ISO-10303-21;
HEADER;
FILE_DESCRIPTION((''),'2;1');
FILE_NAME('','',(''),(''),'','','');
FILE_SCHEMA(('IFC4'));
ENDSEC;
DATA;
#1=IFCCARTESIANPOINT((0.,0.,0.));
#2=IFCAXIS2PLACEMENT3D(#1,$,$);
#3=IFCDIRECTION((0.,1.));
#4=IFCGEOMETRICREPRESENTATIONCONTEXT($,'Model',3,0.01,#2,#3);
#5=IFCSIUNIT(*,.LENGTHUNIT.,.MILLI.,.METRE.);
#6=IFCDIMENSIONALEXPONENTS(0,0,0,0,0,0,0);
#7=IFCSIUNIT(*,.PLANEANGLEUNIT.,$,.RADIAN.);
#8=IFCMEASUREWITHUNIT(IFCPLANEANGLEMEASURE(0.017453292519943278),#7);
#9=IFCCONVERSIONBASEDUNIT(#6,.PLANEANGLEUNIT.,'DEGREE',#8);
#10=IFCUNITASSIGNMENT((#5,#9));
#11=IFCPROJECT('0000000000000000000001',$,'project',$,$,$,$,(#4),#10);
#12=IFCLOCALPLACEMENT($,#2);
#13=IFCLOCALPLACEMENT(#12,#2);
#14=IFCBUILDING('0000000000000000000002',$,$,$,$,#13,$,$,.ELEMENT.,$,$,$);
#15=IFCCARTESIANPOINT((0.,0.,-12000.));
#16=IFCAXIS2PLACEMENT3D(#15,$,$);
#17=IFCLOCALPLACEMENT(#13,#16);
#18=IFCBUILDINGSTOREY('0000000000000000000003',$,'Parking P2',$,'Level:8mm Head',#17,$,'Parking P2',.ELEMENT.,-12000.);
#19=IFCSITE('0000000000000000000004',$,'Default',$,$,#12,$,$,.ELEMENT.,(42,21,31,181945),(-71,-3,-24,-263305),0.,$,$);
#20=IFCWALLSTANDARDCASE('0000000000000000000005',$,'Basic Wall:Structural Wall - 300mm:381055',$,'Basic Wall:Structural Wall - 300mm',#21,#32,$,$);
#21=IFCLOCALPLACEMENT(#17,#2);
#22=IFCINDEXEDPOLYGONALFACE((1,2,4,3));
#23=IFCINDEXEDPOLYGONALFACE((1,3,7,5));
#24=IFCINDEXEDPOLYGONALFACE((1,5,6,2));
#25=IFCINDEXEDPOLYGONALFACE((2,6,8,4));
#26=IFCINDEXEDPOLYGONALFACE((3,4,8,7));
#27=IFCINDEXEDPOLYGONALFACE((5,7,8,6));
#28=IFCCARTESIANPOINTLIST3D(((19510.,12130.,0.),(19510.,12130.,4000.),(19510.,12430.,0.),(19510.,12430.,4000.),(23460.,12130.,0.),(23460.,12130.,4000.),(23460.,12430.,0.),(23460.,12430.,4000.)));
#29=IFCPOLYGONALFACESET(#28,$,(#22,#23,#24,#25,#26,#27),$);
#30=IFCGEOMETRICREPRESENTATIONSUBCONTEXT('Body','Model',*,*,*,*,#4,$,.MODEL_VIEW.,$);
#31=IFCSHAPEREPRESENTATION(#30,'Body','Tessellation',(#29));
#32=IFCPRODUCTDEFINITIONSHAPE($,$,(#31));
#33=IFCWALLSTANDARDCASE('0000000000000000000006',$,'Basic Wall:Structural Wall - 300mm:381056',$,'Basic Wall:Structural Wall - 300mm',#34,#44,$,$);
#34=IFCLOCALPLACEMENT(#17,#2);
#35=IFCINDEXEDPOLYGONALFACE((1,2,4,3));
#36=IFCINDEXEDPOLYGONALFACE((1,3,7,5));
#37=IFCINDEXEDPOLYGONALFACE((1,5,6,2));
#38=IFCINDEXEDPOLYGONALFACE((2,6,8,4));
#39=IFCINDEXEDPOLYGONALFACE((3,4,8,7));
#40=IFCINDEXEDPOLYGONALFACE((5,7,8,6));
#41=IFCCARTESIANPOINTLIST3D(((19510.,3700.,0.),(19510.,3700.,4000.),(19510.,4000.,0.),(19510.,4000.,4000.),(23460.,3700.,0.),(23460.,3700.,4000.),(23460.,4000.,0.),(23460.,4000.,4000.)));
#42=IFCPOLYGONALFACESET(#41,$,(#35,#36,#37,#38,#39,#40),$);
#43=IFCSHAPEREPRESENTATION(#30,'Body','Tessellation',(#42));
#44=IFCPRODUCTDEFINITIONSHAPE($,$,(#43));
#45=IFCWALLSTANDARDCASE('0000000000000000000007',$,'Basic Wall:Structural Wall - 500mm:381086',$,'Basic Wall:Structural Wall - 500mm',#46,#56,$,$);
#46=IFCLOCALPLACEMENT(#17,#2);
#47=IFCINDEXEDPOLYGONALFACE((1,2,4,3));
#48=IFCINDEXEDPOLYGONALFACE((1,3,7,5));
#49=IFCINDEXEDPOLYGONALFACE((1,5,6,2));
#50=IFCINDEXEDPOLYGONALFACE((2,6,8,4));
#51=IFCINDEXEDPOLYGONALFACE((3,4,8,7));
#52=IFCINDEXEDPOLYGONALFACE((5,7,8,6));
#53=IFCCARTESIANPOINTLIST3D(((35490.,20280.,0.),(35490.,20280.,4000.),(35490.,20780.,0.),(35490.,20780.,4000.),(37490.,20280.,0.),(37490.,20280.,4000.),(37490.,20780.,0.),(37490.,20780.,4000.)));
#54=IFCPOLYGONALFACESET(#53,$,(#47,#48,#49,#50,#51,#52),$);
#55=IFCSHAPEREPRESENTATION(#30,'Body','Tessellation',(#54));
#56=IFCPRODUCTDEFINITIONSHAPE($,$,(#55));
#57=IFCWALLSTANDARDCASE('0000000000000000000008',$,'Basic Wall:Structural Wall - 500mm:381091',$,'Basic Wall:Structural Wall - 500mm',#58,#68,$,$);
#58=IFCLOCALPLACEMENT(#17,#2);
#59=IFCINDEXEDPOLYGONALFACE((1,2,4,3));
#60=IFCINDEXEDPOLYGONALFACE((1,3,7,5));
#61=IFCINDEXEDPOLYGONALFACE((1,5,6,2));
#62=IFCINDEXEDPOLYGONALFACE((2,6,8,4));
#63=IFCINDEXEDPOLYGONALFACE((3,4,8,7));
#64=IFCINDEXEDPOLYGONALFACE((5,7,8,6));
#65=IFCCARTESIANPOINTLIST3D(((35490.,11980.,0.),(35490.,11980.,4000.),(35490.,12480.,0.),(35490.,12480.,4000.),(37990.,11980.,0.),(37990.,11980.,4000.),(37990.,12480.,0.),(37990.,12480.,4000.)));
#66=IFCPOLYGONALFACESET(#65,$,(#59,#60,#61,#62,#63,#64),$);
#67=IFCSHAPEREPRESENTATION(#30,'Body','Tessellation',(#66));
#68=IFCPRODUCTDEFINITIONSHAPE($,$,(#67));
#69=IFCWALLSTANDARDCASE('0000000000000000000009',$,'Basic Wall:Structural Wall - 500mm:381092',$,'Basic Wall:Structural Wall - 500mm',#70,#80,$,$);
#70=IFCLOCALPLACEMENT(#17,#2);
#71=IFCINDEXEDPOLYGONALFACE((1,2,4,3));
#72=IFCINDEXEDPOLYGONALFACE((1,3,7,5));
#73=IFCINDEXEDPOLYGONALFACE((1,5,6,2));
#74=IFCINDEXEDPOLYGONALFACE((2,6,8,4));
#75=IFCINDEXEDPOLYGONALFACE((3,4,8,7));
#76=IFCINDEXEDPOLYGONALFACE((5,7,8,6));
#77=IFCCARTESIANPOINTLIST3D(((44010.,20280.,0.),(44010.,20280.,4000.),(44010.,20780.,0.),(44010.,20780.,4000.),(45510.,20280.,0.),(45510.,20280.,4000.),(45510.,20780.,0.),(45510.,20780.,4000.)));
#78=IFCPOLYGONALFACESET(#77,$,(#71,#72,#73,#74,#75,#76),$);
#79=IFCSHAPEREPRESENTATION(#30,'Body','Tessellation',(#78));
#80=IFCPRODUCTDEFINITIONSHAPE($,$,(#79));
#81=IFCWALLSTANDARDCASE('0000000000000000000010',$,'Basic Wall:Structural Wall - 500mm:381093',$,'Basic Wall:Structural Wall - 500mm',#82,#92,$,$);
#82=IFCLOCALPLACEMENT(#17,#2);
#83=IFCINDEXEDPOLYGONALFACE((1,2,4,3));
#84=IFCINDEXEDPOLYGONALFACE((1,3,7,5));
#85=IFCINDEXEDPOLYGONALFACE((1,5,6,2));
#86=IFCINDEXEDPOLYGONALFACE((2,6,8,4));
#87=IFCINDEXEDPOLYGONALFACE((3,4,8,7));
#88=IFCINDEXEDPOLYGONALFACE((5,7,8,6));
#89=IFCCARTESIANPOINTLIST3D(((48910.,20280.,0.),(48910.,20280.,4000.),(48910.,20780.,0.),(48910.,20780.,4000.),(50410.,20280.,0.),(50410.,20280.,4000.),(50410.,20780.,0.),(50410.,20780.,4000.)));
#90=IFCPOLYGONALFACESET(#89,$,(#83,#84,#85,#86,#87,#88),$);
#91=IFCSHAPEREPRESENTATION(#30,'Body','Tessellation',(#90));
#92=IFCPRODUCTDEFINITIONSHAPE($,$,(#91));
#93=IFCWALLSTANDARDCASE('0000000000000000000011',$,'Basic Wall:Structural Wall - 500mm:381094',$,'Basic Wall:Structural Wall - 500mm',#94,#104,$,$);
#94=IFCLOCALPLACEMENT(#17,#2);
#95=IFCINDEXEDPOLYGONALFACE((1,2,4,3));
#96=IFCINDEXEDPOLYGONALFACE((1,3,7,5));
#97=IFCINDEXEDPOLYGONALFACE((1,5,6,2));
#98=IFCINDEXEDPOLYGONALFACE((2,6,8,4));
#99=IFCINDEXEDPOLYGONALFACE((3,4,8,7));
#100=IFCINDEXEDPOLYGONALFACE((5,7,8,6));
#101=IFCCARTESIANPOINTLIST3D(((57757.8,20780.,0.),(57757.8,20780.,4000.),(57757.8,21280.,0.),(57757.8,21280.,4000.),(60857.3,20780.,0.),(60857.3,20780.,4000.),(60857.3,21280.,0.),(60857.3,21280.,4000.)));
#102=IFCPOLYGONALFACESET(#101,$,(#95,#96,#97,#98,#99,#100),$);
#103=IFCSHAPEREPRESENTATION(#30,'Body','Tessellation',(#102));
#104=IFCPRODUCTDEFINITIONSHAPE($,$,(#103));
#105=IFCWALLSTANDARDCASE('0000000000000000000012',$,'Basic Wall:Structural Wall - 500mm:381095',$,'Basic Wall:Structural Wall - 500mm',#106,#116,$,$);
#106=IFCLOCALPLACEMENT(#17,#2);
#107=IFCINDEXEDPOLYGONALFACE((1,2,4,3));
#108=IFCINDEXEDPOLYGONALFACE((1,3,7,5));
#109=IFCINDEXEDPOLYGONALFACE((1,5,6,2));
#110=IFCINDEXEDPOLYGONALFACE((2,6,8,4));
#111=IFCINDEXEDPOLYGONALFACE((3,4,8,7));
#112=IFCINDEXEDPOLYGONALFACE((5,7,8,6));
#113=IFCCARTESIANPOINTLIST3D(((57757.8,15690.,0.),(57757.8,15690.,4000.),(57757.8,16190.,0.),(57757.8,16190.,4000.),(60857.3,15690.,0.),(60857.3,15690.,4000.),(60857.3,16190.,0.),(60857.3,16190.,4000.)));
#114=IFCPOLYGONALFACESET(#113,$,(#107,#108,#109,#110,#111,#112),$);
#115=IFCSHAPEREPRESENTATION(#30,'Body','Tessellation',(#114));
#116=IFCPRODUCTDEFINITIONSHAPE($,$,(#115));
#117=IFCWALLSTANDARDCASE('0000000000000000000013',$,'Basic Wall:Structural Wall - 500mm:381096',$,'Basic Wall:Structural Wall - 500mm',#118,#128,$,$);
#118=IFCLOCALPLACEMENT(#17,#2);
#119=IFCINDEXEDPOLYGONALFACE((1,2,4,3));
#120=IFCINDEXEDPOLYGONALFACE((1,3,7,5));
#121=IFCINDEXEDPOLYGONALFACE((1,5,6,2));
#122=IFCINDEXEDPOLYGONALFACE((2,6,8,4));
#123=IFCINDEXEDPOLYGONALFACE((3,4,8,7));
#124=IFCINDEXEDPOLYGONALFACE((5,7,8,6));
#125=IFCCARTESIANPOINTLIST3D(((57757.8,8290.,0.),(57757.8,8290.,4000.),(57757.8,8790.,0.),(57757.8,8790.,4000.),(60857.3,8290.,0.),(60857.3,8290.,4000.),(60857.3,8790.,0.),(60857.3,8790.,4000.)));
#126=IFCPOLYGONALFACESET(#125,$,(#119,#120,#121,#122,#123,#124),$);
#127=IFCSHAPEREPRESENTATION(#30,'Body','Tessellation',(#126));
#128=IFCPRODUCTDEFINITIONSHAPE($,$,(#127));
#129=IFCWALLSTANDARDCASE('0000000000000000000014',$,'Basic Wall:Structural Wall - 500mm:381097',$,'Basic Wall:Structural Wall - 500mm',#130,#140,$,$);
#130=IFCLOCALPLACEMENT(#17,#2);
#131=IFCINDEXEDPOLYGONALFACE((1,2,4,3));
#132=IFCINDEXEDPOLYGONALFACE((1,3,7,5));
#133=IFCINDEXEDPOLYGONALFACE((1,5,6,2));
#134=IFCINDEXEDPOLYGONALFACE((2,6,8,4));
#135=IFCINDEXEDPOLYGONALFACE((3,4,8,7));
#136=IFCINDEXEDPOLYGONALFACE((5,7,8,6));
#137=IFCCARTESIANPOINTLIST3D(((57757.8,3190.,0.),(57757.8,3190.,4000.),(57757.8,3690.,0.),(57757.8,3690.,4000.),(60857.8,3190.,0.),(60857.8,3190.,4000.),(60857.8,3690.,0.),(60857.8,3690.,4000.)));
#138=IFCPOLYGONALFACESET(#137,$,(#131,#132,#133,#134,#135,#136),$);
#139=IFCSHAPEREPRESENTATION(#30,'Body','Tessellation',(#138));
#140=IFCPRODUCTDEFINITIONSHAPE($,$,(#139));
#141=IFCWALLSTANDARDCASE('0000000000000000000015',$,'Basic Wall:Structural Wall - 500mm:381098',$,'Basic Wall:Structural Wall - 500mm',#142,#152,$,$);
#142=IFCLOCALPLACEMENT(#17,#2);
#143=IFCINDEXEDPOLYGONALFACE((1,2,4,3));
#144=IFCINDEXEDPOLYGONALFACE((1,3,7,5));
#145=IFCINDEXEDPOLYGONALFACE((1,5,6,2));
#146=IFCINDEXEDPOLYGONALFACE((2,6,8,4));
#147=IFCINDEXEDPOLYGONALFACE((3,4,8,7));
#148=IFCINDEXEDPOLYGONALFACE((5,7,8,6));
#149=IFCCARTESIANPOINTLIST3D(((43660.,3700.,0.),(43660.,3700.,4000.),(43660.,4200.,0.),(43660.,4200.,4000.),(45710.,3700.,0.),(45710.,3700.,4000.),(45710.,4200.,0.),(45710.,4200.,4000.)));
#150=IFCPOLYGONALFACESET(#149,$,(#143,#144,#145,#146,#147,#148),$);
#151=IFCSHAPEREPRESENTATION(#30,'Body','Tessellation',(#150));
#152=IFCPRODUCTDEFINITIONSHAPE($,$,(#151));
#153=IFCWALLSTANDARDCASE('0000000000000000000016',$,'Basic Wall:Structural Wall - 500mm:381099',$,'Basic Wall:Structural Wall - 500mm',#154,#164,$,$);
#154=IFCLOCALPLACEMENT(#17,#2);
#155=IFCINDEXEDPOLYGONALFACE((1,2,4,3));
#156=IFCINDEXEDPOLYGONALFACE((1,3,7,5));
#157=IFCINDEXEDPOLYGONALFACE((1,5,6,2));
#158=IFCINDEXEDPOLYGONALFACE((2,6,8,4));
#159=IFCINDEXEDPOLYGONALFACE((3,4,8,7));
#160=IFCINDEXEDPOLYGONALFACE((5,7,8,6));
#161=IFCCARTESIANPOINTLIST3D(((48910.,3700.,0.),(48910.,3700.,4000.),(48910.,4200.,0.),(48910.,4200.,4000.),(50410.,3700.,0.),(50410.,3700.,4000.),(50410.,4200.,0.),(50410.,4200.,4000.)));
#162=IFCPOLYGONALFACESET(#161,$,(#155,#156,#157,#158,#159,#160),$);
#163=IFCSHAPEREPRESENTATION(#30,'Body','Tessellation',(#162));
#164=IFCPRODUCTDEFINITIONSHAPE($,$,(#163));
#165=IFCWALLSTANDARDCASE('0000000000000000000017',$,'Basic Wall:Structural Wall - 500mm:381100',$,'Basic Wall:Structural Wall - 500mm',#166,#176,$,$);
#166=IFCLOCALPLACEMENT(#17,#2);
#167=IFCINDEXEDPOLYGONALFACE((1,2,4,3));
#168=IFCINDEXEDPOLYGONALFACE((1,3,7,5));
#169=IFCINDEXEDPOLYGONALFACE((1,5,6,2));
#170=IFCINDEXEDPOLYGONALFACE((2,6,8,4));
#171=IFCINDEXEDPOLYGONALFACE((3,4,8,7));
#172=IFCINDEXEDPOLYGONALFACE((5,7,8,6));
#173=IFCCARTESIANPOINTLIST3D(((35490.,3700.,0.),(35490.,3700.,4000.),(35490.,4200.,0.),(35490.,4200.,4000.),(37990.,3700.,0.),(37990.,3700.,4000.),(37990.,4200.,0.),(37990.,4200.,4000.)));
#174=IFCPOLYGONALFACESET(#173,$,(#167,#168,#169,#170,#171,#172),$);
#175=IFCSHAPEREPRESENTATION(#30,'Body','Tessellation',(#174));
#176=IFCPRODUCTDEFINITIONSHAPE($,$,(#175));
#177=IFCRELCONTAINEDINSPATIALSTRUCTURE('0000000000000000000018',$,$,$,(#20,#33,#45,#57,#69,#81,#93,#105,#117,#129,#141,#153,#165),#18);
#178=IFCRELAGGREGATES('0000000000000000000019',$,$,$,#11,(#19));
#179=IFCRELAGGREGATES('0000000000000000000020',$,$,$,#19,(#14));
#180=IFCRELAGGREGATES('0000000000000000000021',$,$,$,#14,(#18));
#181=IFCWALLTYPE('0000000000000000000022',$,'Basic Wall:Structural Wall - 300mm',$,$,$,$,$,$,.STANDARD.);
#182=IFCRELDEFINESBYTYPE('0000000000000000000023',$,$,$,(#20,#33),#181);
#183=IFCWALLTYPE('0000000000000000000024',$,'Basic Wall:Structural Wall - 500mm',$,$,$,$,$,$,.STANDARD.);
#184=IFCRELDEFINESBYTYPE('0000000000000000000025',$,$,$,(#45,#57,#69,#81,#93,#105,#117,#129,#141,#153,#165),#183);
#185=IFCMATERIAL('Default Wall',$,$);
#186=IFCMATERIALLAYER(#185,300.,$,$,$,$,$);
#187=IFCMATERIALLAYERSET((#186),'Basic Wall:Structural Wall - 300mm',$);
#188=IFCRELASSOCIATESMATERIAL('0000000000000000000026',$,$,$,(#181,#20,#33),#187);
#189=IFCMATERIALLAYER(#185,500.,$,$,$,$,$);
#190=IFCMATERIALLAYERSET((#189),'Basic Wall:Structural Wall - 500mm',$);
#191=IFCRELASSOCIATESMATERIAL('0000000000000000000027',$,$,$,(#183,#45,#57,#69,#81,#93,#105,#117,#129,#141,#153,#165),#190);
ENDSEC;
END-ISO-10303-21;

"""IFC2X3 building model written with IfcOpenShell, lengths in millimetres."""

from ifc_helpers import new_model, entity, si_unit, converted_unit, direction, frame, frame_2d, origin, place, context, subcontext, project, spatial, rectangle, extrude, material, layer, layer_set, layer_usage, type_object, element, save


model = new_model("IFC2X3")

# Units and contexts
model_context = context("Model", 3, precision=0.01, world=origin(), true_north=direction((0.0, 1.0)))
body_context = subcontext(model_context, "Body", "Model", "MODEL_VIEW")
ifc_project = project(units=[si_unit("LENGTHUNIT", "METRE", prefix="MILLI"), converted_unit("PLANEANGLEUNIT", "DEGREE", entity("IfcPlaneAngleMeasure", 0.017453292519943278), si_unit("PLANEANGLEUNIT", "RADIAN"), dimensions=[0, 0, 0, 0, 0, 0, 0])], contexts=[model_context])

# Site, building, storey
site_placement = place(None, origin())
site = spatial("IfcSite", under=ifc_project, at=site_placement, Name="Default", CompositionType="ELEMENT", RefLatitude=(42, 21, 31, 181945), RefLongitude=(-71, -3, -24, -263305), RefElevation=0.0)
building_placement = place(site_placement, origin())
building = spatial("IfcBuilding", under=site, at=building_placement, CompositionType="ELEMENT")
storey_placement = place(building_placement, frame((0.0, 0.0, -12000.0)))
storey = spatial("IfcBuildingStorey", under=building, at=storey_placement, Name="Parking P2", ObjectType="Level:8mm Head", LongName="Parking P2", CompositionType="ELEMENT", Elevation=-12000.0)

# Walls
ifc_material_1 = material(Name="Default Wall")
ifc_layer_1 = layer(ifc_material_1, 300.0)
ifc_layer_set_1 = layer_set([ifc_layer_1], Name="Basic Wall:Structural Wall - 300mm")
ifc_layer_usage_1 = layer_usage(ifc_layer_set_1, "AXIS2", "NEGATIVE", 150.0)
wall_type_1 = type_object("IfcWallType", Name="Basic Wall:Structural Wall - 300mm", PredefinedType="STANDARD", material=ifc_layer_set_1)
wall_1_placement = place(storey_placement, frame((19510.0, 12280.0, 0.0)))
element("IfcWallStandardCase", 1, at=wall_1_placement, inside=storey, type_object=wall_type_1, material=ifc_layer_usage_1, Name="Basic Wall:Structural Wall - 300mm:381055", ObjectType="Basic Wall:Structural Wall - 300mm", context=body_context, shape_type="SweptSolid", body=[
    extrude(rectangle(XDim=3950.0, YDim=300.0, at=frame_2d((1975.0, 0.0), x_axis=(-1.0, 0.0))), origin(), (0.0, 0.0, 1.0), 4000.0),
])
ifc_layer_usage_2 = layer_usage(ifc_layer_set_1, "AXIS2", "NEGATIVE", 150.0)
wall_2_placement = place(storey_placement, frame((19510.0, 3850.0, 0.0)))
element("IfcWallStandardCase", 2, at=wall_2_placement, inside=storey, type_object=wall_type_1, material=ifc_layer_usage_2, Name="Basic Wall:Structural Wall - 300mm:381056", ObjectType="Basic Wall:Structural Wall - 300mm", context=body_context, shape_type="SweptSolid", body=[
    extrude(rectangle(XDim=3950.0, YDim=300.0, at=frame_2d((1975.0, 0.0), x_axis=(-1.0, 0.0))), origin(), (0.0, 0.0, 1.0), 4000.0),
])
ifc_layer_2 = layer(ifc_material_1, 500.0)
ifc_layer_set_2 = layer_set([ifc_layer_2], Name="Basic Wall:Structural Wall - 500mm")
ifc_layer_usage_3 = layer_usage(ifc_layer_set_2, "AXIS2", "NEGATIVE", 250.0)
wall_type_2 = type_object("IfcWallType", Name="Basic Wall:Structural Wall - 500mm", PredefinedType="STANDARD", material=ifc_layer_set_2)
wall_3_placement = place(storey_placement, frame((35490.0, 20530.0, 0.0)))
element("IfcWallStandardCase", 3, at=wall_3_placement, inside=storey, type_object=wall_type_2, material=ifc_layer_usage_3, Name="Basic Wall:Structural Wall - 500mm:381086", ObjectType="Basic Wall:Structural Wall - 500mm", context=body_context, shape_type="SweptSolid", body=[
    extrude(rectangle(XDim=2000.0, YDim=500.0, at=frame_2d((1000.0, 0.0), x_axis=(-1.0, 0.0))), origin(), (0.0, 0.0, 1.0), 4000.0),
])
ifc_layer_usage_4 = layer_usage(ifc_layer_set_2, "AXIS2", "NEGATIVE", 250.0)
wall_4_placement = place(storey_placement, frame((35490.0, 12230.0, 0.0)))
element("IfcWallStandardCase", 4, at=wall_4_placement, inside=storey, type_object=wall_type_2, material=ifc_layer_usage_4, Name="Basic Wall:Structural Wall - 500mm:381091", ObjectType="Basic Wall:Structural Wall - 500mm", context=body_context, shape_type="SweptSolid", body=[
    extrude(rectangle(XDim=2500.0, YDim=500.0, at=frame_2d((1250.0, 0.0), x_axis=(-1.0, 0.0))), origin(), (0.0, 0.0, 1.0), 4000.0),
])
ifc_layer_usage_5 = layer_usage(ifc_layer_set_2, "AXIS2", "NEGATIVE", 250.0)
wall_5_placement = place(storey_placement, frame((44010.0, 20530.0, 0.0)))
element("IfcWallStandardCase", 5, at=wall_5_placement, inside=storey, type_object=wall_type_2, material=ifc_layer_usage_5, Name="Basic Wall:Structural Wall - 500mm:381092", ObjectType="Basic Wall:Structural Wall - 500mm", context=body_context, shape_type="SweptSolid", body=[
    extrude(rectangle(XDim=1500.0, YDim=500.0, at=frame_2d((750.0, 0.0), x_axis=(-1.0, 0.0))), origin(), (0.0, 0.0, 1.0), 4000.0),
])
ifc_layer_usage_6 = layer_usage(ifc_layer_set_2, "AXIS2", "NEGATIVE", 250.0)
wall_6_placement = place(storey_placement, frame((48910.0, 20530.0, 0.0)))
element("IfcWallStandardCase", 6, at=wall_6_placement, inside=storey, type_object=wall_type_2, material=ifc_layer_usage_6, Name="Basic Wall:Structural Wall - 500mm:381093", ObjectType="Basic Wall:Structural Wall - 500mm", context=body_context, shape_type="SweptSolid", body=[
    extrude(rectangle(XDim=1500.0, YDim=500.0, at=frame_2d((750.0, 0.0), x_axis=(-1.0, 0.0))), origin(), (0.0, 0.0, 1.0), 4000.0),
])
ifc_layer_usage_7 = layer_usage(ifc_layer_set_2, "AXIS2", "NEGATIVE", 250.0)
wall_7_placement = place(storey_placement, frame((57757.8, 21030.0, 0.0)))
element("IfcWallStandardCase", 7, at=wall_7_placement, inside=storey, type_object=wall_type_2, material=ifc_layer_usage_7, Name="Basic Wall:Structural Wall - 500mm:381094", ObjectType="Basic Wall:Structural Wall - 500mm", context=body_context, shape_type="SweptSolid", body=[
    extrude(rectangle(XDim=3099.5, YDim=500.0, at=frame_2d((1549.8, 0.0), x_axis=(-1.0, 0.0))), origin(), (0.0, 0.0, 1.0), 4000.0),
])
ifc_layer_usage_8 = layer_usage(ifc_layer_set_2, "AXIS2", "NEGATIVE", 250.0)
wall_8_placement = place(storey_placement, frame((57757.8, 15940.0, 0.0)))
element("IfcWallStandardCase", 8, at=wall_8_placement, inside=storey, type_object=wall_type_2, material=ifc_layer_usage_8, Name="Basic Wall:Structural Wall - 500mm:381095", ObjectType="Basic Wall:Structural Wall - 500mm", context=body_context, shape_type="SweptSolid", body=[
    extrude(rectangle(XDim=3099.5, YDim=500.0, at=frame_2d((1549.8, 0.0), x_axis=(-1.0, 0.0))), origin(), (0.0, 0.0, 1.0), 4000.0),
])
ifc_layer_usage_9 = layer_usage(ifc_layer_set_2, "AXIS2", "NEGATIVE", 250.0)
wall_9_placement = place(storey_placement, frame((57757.8, 8540.0, 0.0)))
element("IfcWallStandardCase", 9, at=wall_9_placement, inside=storey, type_object=wall_type_2, material=ifc_layer_usage_9, Name="Basic Wall:Structural Wall - 500mm:381096", ObjectType="Basic Wall:Structural Wall - 500mm", context=body_context, shape_type="SweptSolid", body=[
    extrude(rectangle(XDim=3099.5, YDim=500.0, at=frame_2d((1549.8, 0.0), x_axis=(-1.0, 0.0))), origin(), (0.0, 0.0, 1.0), 4000.0),
])
ifc_layer_usage_10 = layer_usage(ifc_layer_set_2, "AXIS2", "NEGATIVE", 250.0)
wall_10_placement = place(storey_placement, frame((57757.8, 3440.0, 0.0)))
element("IfcWallStandardCase", 10, at=wall_10_placement, inside=storey, type_object=wall_type_2, material=ifc_layer_usage_10, Name="Basic Wall:Structural Wall - 500mm:381097", ObjectType="Basic Wall:Structural Wall - 500mm", context=body_context, shape_type="SweptSolid", body=[
    extrude(rectangle(XDim=3100.0, YDim=500.0, at=frame_2d((1550.0, 0.0), x_axis=(-1.0, 0.0))), origin(), (0.0, 0.0, 1.0), 4000.0),
])
ifc_layer_usage_11 = layer_usage(ifc_layer_set_2, "AXIS2", "NEGATIVE", 250.0)
wall_11_placement = place(storey_placement, frame((43660.0, 3950.0, 0.0)))
element("IfcWallStandardCase", 11, at=wall_11_placement, inside=storey, type_object=wall_type_2, material=ifc_layer_usage_11, Name="Basic Wall:Structural Wall - 500mm:381098", ObjectType="Basic Wall:Structural Wall - 500mm", context=body_context, shape_type="SweptSolid", body=[
    extrude(rectangle(XDim=2050.0, YDim=500.0, at=frame_2d((1025.0, 0.0), x_axis=(-1.0, 0.0))), origin(), (0.0, 0.0, 1.0), 4000.0),
])
ifc_layer_usage_12 = layer_usage(ifc_layer_set_2, "AXIS2", "NEGATIVE", 250.0)
wall_12_placement = place(storey_placement, frame((48910.0, 3950.0, 0.0)))
element("IfcWallStandardCase", 12, at=wall_12_placement, inside=storey, type_object=wall_type_2, material=ifc_layer_usage_12, Name="Basic Wall:Structural Wall - 500mm:381099", ObjectType="Basic Wall:Structural Wall - 500mm", context=body_context, shape_type="SweptSolid", body=[
    extrude(rectangle(XDim=1500.0, YDim=500.0, at=frame_2d((750.0, 0.0), x_axis=(-1.0, 0.0))), origin(), (0.0, 0.0, 1.0), 4000.0),
])
ifc_layer_usage_13 = layer_usage(ifc_layer_set_2, "AXIS2", "NEGATIVE", 250.0)
wall_13_placement = place(storey_placement, frame((35490.0, 3950.0, 0.0)))
element("IfcWallStandardCase", 13, at=wall_13_placement, inside=storey, type_object=wall_type_2, material=ifc_layer_usage_13, Name="Basic Wall:Structural Wall - 500mm:381100", ObjectType="Basic Wall:Structural Wall - 500mm", context=body_context, shape_type="SweptSolid", body=[
    extrude(rectangle(XDim=2500.0, YDim=500.0, at=frame_2d((1250.0, 0.0), x_axis=(-1.0, 0.0))), origin(), (0.0, 0.0, 1.0), 4000.0),
])

save(model, "model.ifc")
